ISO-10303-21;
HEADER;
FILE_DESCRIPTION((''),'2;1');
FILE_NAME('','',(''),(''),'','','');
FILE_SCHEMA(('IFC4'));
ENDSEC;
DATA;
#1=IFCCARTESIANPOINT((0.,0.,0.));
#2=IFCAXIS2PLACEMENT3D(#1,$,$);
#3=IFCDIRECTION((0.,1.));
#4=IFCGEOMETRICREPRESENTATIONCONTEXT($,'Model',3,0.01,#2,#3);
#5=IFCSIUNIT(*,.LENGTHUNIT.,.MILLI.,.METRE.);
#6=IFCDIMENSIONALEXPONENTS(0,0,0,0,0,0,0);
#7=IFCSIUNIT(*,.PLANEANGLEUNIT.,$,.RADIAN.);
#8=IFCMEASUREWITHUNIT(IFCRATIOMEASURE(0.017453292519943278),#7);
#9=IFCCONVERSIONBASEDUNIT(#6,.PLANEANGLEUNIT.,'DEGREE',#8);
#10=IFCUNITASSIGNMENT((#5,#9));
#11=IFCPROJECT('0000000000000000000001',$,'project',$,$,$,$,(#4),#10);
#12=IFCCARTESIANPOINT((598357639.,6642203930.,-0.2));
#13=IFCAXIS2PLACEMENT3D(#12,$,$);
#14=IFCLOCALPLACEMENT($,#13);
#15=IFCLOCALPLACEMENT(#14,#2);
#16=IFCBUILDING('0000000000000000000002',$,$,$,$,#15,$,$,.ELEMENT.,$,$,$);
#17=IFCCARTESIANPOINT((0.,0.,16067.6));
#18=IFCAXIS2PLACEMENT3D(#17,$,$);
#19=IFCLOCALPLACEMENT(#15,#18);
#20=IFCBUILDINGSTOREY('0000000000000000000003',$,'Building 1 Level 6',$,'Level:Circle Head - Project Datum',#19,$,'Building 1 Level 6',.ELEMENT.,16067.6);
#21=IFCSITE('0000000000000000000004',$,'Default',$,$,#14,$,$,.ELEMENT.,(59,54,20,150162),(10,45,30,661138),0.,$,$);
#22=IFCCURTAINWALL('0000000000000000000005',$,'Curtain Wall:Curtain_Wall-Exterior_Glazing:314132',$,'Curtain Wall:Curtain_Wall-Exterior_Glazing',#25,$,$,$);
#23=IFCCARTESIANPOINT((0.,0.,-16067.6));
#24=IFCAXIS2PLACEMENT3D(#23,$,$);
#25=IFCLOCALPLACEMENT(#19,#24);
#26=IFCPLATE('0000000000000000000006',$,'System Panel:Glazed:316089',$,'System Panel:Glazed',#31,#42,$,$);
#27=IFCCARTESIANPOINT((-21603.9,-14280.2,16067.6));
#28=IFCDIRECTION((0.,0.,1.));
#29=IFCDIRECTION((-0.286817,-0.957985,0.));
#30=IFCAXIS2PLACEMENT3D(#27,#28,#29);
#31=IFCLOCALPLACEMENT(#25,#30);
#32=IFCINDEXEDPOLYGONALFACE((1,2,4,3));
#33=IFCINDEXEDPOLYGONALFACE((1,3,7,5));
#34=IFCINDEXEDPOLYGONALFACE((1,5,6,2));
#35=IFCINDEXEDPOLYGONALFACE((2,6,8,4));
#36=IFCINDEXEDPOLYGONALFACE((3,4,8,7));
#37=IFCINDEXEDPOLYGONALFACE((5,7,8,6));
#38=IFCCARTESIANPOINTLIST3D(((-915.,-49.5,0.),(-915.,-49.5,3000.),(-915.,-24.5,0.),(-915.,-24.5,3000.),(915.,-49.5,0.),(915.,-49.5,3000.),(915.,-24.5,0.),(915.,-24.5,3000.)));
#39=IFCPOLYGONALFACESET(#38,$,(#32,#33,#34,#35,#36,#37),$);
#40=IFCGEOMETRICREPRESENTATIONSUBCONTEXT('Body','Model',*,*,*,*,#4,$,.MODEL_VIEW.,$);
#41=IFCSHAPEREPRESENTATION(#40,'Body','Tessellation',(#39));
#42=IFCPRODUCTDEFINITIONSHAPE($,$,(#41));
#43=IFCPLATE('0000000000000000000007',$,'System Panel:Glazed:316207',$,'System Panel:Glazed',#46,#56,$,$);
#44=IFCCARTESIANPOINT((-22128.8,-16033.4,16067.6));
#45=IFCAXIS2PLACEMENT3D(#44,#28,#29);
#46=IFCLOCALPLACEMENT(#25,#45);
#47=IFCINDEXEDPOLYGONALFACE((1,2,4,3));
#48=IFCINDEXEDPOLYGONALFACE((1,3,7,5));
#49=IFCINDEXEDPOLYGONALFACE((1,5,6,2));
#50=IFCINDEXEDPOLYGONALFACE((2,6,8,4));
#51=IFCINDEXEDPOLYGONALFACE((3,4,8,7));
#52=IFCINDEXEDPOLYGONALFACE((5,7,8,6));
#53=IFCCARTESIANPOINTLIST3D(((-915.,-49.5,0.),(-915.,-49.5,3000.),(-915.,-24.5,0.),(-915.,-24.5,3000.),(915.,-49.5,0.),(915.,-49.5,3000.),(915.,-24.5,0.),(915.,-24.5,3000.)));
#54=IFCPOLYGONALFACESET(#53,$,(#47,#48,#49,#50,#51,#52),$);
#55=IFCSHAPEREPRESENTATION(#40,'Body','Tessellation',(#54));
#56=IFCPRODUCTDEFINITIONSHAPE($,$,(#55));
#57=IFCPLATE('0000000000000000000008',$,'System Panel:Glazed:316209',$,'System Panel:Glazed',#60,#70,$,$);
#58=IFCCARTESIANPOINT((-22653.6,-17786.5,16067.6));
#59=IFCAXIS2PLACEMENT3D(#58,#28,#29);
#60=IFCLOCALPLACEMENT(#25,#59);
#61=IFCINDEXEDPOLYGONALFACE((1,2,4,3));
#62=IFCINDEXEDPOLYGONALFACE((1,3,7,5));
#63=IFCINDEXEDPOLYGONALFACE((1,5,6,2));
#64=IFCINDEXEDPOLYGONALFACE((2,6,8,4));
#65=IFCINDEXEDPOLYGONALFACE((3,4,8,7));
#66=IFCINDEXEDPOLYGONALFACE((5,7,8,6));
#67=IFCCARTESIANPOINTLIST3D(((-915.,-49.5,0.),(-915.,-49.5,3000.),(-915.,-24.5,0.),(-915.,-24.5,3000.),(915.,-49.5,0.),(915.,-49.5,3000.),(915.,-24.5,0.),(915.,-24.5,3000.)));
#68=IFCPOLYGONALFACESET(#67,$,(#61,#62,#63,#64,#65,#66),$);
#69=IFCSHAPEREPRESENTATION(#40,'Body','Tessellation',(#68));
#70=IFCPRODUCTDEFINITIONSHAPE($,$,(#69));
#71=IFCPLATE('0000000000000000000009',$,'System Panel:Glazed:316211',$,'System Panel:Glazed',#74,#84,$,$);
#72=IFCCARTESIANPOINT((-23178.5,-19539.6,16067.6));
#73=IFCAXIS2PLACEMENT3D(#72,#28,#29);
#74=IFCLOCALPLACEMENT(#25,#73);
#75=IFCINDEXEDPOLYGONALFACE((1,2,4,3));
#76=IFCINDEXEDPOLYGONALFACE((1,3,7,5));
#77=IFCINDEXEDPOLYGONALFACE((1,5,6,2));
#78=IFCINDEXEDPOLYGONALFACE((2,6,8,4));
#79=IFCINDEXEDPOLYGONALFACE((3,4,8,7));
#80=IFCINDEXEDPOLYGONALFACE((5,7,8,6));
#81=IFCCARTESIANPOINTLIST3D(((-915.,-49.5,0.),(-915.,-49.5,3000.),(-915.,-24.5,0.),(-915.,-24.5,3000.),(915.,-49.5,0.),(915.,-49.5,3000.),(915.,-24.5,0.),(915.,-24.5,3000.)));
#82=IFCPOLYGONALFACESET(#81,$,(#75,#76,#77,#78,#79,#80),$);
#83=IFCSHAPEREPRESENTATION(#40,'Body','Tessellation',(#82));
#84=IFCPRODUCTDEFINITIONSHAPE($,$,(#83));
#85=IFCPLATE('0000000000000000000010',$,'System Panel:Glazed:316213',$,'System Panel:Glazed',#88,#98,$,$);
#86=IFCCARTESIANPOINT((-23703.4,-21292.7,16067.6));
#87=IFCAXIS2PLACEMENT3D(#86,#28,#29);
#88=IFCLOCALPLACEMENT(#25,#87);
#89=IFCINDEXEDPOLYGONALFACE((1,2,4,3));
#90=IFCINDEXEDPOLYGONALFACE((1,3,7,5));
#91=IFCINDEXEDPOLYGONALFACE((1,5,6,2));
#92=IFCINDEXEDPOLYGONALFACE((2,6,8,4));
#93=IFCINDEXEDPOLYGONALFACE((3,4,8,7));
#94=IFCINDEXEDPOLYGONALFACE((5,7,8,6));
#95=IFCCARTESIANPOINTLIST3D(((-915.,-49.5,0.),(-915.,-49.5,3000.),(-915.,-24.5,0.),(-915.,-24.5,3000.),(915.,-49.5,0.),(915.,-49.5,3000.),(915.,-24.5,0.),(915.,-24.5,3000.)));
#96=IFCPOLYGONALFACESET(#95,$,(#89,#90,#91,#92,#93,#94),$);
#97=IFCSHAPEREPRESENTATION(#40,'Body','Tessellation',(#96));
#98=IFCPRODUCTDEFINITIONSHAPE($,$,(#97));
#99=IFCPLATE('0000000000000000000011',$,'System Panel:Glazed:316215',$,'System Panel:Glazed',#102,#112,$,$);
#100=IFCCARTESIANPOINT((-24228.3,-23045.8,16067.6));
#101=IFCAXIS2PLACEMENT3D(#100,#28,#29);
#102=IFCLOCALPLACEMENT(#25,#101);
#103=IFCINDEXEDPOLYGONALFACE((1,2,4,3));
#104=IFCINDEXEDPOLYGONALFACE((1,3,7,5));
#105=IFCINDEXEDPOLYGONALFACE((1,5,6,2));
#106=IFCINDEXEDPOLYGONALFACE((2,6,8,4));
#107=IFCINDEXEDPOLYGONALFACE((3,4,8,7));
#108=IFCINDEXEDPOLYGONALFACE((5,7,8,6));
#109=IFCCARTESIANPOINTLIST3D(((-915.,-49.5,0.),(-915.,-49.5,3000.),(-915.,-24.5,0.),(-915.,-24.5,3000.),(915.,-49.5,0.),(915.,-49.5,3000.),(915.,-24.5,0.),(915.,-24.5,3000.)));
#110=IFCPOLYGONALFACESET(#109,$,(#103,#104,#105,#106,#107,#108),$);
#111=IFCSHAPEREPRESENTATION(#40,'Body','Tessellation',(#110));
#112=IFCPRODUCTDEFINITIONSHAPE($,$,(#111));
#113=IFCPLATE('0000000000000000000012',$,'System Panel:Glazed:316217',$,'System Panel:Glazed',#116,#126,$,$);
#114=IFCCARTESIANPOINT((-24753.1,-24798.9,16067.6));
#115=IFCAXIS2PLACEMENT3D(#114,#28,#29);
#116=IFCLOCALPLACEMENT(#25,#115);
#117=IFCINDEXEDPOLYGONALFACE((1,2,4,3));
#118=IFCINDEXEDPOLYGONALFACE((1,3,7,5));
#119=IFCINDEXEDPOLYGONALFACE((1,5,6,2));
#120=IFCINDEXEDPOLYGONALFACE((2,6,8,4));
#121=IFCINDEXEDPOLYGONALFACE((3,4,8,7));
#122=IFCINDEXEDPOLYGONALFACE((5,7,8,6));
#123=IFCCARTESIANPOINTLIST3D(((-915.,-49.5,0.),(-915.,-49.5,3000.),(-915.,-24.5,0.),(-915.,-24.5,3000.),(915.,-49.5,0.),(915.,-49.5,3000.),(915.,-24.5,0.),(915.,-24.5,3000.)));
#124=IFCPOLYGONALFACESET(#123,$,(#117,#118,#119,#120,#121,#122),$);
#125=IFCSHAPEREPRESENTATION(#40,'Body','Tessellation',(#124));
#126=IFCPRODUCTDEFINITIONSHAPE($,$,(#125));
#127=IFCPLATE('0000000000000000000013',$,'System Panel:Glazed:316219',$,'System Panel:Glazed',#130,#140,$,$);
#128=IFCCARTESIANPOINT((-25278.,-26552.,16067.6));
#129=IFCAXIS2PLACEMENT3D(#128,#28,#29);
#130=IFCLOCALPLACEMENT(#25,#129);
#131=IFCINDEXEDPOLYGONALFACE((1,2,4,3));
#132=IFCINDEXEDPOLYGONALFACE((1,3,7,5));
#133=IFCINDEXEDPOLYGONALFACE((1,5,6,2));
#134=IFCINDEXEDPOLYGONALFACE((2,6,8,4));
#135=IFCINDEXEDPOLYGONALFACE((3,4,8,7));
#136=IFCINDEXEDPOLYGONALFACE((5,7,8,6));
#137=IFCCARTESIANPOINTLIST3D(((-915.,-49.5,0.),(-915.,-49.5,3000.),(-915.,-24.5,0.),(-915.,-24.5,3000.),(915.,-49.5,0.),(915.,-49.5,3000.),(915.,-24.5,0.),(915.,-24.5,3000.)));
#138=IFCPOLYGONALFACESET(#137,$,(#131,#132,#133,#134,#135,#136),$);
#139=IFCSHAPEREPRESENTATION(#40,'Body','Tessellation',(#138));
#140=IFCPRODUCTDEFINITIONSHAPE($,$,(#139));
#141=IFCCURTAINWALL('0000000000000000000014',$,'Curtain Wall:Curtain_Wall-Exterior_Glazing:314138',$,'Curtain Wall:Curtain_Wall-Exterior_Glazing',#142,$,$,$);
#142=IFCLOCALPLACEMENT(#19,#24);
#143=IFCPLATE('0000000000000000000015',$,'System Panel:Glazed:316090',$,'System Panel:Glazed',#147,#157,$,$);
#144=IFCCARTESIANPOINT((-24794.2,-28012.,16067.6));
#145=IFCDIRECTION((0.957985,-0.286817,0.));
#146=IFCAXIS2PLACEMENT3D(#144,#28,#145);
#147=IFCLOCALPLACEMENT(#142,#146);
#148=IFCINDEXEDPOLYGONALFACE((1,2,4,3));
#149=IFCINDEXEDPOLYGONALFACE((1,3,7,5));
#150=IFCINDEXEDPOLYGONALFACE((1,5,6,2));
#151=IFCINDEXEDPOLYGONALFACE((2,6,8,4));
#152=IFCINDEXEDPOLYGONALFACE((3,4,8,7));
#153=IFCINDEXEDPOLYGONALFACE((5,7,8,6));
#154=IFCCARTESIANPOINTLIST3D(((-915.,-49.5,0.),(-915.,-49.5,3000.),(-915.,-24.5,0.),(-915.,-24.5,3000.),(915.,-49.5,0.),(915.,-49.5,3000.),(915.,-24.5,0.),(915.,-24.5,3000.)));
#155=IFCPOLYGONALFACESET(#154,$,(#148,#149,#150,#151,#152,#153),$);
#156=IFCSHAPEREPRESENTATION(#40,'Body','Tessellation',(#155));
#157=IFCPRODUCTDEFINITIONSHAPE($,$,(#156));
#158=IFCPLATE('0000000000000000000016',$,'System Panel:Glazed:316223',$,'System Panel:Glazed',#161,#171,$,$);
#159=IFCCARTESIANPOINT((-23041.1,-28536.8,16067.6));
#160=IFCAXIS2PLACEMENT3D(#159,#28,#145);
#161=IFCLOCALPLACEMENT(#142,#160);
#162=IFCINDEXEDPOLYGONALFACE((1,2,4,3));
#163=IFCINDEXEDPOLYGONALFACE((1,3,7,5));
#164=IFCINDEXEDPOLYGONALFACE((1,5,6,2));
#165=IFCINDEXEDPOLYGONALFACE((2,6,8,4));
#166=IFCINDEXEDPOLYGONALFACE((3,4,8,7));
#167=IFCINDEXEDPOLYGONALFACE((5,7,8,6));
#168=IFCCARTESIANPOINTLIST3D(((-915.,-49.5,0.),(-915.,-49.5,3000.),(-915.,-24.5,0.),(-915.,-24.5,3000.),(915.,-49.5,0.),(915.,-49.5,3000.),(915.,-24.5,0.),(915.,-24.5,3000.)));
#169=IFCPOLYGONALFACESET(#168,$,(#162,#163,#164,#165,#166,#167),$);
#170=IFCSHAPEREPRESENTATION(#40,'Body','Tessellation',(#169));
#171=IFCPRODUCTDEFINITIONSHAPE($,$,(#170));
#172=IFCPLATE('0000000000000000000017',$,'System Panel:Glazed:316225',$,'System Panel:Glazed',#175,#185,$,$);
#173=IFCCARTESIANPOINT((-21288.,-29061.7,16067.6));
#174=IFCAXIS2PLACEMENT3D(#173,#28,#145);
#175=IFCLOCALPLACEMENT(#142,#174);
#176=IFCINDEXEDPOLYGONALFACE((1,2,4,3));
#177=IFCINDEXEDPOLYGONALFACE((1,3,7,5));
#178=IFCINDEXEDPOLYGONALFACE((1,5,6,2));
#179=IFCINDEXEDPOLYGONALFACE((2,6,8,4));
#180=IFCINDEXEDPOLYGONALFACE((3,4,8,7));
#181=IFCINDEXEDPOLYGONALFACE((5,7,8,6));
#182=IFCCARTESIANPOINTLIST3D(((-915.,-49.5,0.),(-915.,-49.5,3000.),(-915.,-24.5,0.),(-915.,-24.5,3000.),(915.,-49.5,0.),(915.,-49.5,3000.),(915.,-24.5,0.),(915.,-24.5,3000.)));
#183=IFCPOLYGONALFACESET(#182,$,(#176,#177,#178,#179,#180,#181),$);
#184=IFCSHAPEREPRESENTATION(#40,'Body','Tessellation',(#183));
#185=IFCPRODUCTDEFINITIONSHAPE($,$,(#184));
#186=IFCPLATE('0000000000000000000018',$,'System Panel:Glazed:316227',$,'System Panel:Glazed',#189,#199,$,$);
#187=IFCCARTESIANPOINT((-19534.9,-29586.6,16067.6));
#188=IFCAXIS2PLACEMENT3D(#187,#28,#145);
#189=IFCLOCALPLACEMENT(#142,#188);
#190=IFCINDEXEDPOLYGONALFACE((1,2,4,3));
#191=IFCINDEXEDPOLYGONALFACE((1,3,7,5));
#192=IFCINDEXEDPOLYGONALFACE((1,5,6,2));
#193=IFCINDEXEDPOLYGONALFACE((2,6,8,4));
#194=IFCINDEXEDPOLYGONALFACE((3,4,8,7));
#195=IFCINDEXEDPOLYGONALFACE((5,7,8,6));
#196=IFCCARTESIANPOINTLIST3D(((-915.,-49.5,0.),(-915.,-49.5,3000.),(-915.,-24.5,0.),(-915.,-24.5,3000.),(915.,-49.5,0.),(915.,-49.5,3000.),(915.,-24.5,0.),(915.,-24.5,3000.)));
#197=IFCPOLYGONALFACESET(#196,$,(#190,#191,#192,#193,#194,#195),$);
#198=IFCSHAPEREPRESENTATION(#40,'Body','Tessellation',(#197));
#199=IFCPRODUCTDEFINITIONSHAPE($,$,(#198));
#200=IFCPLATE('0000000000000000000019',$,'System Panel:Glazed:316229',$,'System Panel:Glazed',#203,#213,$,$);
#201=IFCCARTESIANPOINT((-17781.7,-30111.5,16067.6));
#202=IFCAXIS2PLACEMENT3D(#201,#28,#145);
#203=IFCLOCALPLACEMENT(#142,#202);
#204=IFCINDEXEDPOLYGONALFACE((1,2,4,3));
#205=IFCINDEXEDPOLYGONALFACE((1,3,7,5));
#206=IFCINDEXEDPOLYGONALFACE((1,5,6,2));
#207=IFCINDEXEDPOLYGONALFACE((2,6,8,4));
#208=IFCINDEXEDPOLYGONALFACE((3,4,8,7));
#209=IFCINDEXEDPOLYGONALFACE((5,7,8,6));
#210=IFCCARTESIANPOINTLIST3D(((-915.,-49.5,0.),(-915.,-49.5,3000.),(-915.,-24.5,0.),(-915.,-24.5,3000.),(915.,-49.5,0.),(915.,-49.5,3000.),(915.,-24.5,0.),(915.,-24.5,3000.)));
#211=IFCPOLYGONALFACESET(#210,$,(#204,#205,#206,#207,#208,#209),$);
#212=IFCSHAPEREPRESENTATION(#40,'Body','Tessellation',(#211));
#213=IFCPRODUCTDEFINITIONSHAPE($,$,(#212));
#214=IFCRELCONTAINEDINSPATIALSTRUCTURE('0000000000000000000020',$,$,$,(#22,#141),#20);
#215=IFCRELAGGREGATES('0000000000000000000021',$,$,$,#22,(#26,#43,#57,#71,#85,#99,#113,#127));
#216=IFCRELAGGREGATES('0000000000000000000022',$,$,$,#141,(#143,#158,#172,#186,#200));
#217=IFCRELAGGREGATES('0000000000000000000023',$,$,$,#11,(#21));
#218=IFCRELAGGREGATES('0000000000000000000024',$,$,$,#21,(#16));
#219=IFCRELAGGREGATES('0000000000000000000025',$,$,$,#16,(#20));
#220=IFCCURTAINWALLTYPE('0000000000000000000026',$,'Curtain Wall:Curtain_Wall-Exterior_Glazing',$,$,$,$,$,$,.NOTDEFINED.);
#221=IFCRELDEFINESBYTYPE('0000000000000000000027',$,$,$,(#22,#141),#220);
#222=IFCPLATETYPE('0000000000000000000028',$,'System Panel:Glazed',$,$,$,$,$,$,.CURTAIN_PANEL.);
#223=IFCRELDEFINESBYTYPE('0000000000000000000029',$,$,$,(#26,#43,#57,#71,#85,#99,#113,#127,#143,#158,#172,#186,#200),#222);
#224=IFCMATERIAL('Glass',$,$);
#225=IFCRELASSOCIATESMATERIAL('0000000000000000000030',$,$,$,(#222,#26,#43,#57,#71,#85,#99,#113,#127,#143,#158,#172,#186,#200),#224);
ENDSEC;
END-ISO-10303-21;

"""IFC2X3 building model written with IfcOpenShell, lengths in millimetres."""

from ifc_helpers import new_model, entity, si_unit, converted_unit, direction, frame, frame_2d, origin, place, context, subcontext, project, spatial, rectangle, extrude, source, transform, mapped, material, type_object, type_shapes, element, aggregate, save


model = new_model("IFC2X3")

# Units and contexts
model_context = context("Model", 3, precision=0.01, world=origin(), true_north=direction((0.0, 1.0)))
body_context = subcontext(model_context, "Body", "Model", "MODEL_VIEW")
ifc_project = project(units=[si_unit("LENGTHUNIT", "METRE", prefix="MILLI"), converted_unit("PLANEANGLEUNIT", "DEGREE", entity("IfcRatioMeasure", 0.017453292519943278), si_unit("PLANEANGLEUNIT", "RADIAN"), dimensions=[0, 0, 0, 0, 0, 0, 0])], contexts=[model_context])

# Site, building, storey
site_placement = place(None, frame((598357639.0, 6642203930.0, -0.2)))
site = spatial("IfcSite", under=ifc_project, at=site_placement, Name="Default", CompositionType="ELEMENT", RefLatitude=(59, 54, 20, 150162), RefLongitude=(10, 45, 30, 661138), RefElevation=0.0)
building_placement = place(site_placement, origin())
building = spatial("IfcBuilding", under=site, at=building_placement, CompositionType="ELEMENT")
storey_placement = place(building_placement, frame((0.0, 0.0, 16067.6)))
storey = spatial("IfcBuildingStorey", under=building, at=storey_placement, Name="Building 1 Level 6", ObjectType="Level:Circle Head - Project Datum", LongName="Building 1 Level 6", CompositionType="ELEMENT", Elevation=16067.6)

# Curtain walls, plates
curtain_wall_type = type_object("IfcCurtainWallType", Name="Curtain Wall:Curtain_Wall-Exterior_Glazing", PredefinedType="NOTDEFINED")
curtain_wall_1_placement = place(storey_placement, frame((0.0, 0.0, -16067.6)))
curtain_wall_1 = element("IfcCurtainWall", 1, at=curtain_wall_1_placement, inside=storey, type_object=curtain_wall_type, Name="Curtain Wall:Curtain_Wall-Exterior_Glazing:314132", ObjectType="Curtain Wall:Curtain_Wall-Exterior_Glazing")
ifc_material_1 = material(Name="Glass")
plate_type_1 = type_object("IfcPlateType", Name="System Panel:Glazed", PredefinedType="CURTAIN_PANEL", material=ifc_material_1)
shared_shape_1 = source(origin(), body_context, "Body", "SweptSolid", [
    extrude(rectangle(XDim=25.0, YDim=1830.0, at=frame_2d((0.0, 0.0), x_axis=(1.0, 0.0))), frame((0.0, -37.0, 0.0), z_axis=(0.0, 0.0, 1.0), x_axis=(0.0, 1.0, 0.0)), (0.0, 0.0, 1.0), 3000.0),
])
type_shapes(plate_type_1, [shared_shape_1])
plate_1_placement = place(curtain_wall_1_placement, frame((-21603.9, -14280.2, 16067.6), z_axis=(0.0, 0.0, 1.0), x_axis=(-0.286817, -0.957985, 0.0)))
plate_1 = element("IfcPlate", 2, at=plate_1_placement, type_object=plate_type_1, material=ifc_material_1, Name="System Panel:Glazed:316089", ObjectType="System Panel:Glazed", context=body_context, shape_type="MappedRepresentation", body=[
    mapped(shared_shape_1, transform((0.0, 0.0, 0.0), scale=1.0)),
])
plate_2_placement = place(curtain_wall_1_placement, frame((-22128.8, -16033.4, 16067.6), z_axis=(0.0, 0.0, 1.0), x_axis=(-0.286817, -0.957985, 0.0)))
plate_2 = element("IfcPlate", 3, at=plate_2_placement, type_object=plate_type_1, material=ifc_material_1, Name="System Panel:Glazed:316207", ObjectType="System Panel:Glazed", context=body_context, shape_type="MappedRepresentation", body=[
    mapped(shared_shape_1, transform((0.0, 0.0, 0.0), scale=1.0)),
])
plate_3_placement = place(curtain_wall_1_placement, frame((-22653.6, -17786.5, 16067.6), z_axis=(0.0, 0.0, 1.0), x_axis=(-0.286817, -0.957985, 0.0)))
plate_3 = element("IfcPlate", 4, at=plate_3_placement, type_object=plate_type_1, material=ifc_material_1, Name="System Panel:Glazed:316209", ObjectType="System Panel:Glazed", context=body_context, shape_type="MappedRepresentation", body=[
    mapped(shared_shape_1, transform((0.0, 0.0, 0.0), scale=1.0)),
])
plate_4_placement = place(curtain_wall_1_placement, frame((-23178.5, -19539.6, 16067.6), z_axis=(0.0, 0.0, 1.0), x_axis=(-0.286817, -0.957985, 0.0)))
plate_4 = element("IfcPlate", 5, at=plate_4_placement, type_object=plate_type_1, material=ifc_material_1, Name="System Panel:Glazed:316211", ObjectType="System Panel:Glazed", context=body_context, shape_type="MappedRepresentation", body=[
    mapped(shared_shape_1, transform((0.0, 0.0, 0.0), scale=1.0)),
])
plate_5_placement = place(curtain_wall_1_placement, frame((-23703.4, -21292.7, 16067.6), z_axis=(0.0, 0.0, 1.0), x_axis=(-0.286817, -0.957985, 0.0)))
plate_5 = element("IfcPlate", 6, at=plate_5_placement, type_object=plate_type_1, material=ifc_material_1, Name="System Panel:Glazed:316213", ObjectType="System Panel:Glazed", context=body_context, shape_type="MappedRepresentation", body=[
    mapped(shared_shape_1, transform((0.0, 0.0, 0.0), scale=1.0)),
])
plate_6_placement = place(curtain_wall_1_placement, frame((-24228.3, -23045.8, 16067.6), z_axis=(0.0, 0.0, 1.0), x_axis=(-0.286817, -0.957985, 0.0)))
plate_6 = element("IfcPlate", 7, at=plate_6_placement, type_object=plate_type_1, material=ifc_material_1, Name="System Panel:Glazed:316215", ObjectType="System Panel:Glazed", context=body_context, shape_type="MappedRepresentation", body=[
    mapped(shared_shape_1, transform((0.0, 0.0, 0.0), scale=1.0)),
])
plate_7_placement = place(curtain_wall_1_placement, frame((-24753.1, -24798.9, 16067.6), z_axis=(0.0, 0.0, 1.0), x_axis=(-0.286817, -0.957985, 0.0)))
plate_7 = element("IfcPlate", 8, at=plate_7_placement, type_object=plate_type_1, material=ifc_material_1, Name="System Panel:Glazed:316217", ObjectType="System Panel:Glazed", context=body_context, shape_type="MappedRepresentation", body=[
    mapped(shared_shape_1, transform((0.0, 0.0, 0.0), scale=1.0)),
])
plate_8_placement = place(curtain_wall_1_placement, frame((-25278.0, -26552.0, 16067.6), z_axis=(0.0, 0.0, 1.0), x_axis=(-0.286817, -0.957985, 0.0)))
plate_8 = element("IfcPlate", 9, at=plate_8_placement, type_object=plate_type_1, material=ifc_material_1, Name="System Panel:Glazed:316219", ObjectType="System Panel:Glazed", context=body_context, shape_type="MappedRepresentation", body=[
    mapped(shared_shape_1, transform((0.0, 0.0, 0.0), scale=1.0)),
])
curtain_wall_2_placement = place(storey_placement, frame((0.0, 0.0, -16067.6)))
curtain_wall_2 = element("IfcCurtainWall", 10, at=curtain_wall_2_placement, inside=storey, type_object=curtain_wall_type, Name="Curtain Wall:Curtain_Wall-Exterior_Glazing:314138", ObjectType="Curtain Wall:Curtain_Wall-Exterior_Glazing")
plate_9_placement = place(curtain_wall_2_placement, frame((-24794.2, -28012.0, 16067.6), z_axis=(0.0, 0.0, 1.0), x_axis=(0.957985, -0.286817, 0.0)))
plate_9 = element("IfcPlate", 11, at=plate_9_placement, type_object=plate_type_1, material=ifc_material_1, Name="System Panel:Glazed:316090", ObjectType="System Panel:Glazed", context=body_context, shape_type="MappedRepresentation", body=[
    mapped(shared_shape_1, transform((0.0, 0.0, 0.0), scale=1.0)),
])
plate_10_placement = place(curtain_wall_2_placement, frame((-23041.1, -28536.8, 16067.6), z_axis=(0.0, 0.0, 1.0), x_axis=(0.957985, -0.286817, 0.0)))
plate_10 = element("IfcPlate", 12, at=plate_10_placement, type_object=plate_type_1, material=ifc_material_1, Name="System Panel:Glazed:316223", ObjectType="System Panel:Glazed", context=body_context, shape_type="MappedRepresentation", body=[
    mapped(shared_shape_1, transform((0.0, 0.0, 0.0), scale=1.0)),
])
plate_11_placement = place(curtain_wall_2_placement, frame((-21288.0, -29061.7, 16067.6), z_axis=(0.0, 0.0, 1.0), x_axis=(0.957985, -0.286817, 0.0)))
plate_11 = element("IfcPlate", 13, at=plate_11_placement, type_object=plate_type_1, material=ifc_material_1, Name="System Panel:Glazed:316225", ObjectType="System Panel:Glazed", context=body_context, shape_type="MappedRepresentation", body=[
    mapped(shared_shape_1, transform((0.0, 0.0, 0.0), scale=1.0)),
])
plate_12_placement = place(curtain_wall_2_placement, frame((-19534.9, -29586.6, 16067.6), z_axis=(0.0, 0.0, 1.0), x_axis=(0.957985, -0.286817, 0.0)))
plate_12 = element("IfcPlate", 14, at=plate_12_placement, type_object=plate_type_1, material=ifc_material_1, Name="System Panel:Glazed:316227", ObjectType="System Panel:Glazed", context=body_context, shape_type="MappedRepresentation", body=[
    mapped(shared_shape_1, transform((0.0, 0.0, 0.0), scale=1.0)),
])
plate_13_placement = place(curtain_wall_2_placement, frame((-17781.7, -30111.5, 16067.6), z_axis=(0.0, 0.0, 1.0), x_axis=(0.957985, -0.286817, 0.0)))
plate_13 = element("IfcPlate", 15, at=plate_13_placement, type_object=plate_type_1, material=ifc_material_1, Name="System Panel:Glazed:316229", ObjectType="System Panel:Glazed", context=body_context, shape_type="MappedRepresentation", body=[
    mapped(shared_shape_1, transform((0.0, 0.0, 0.0), scale=1.0)),
])

aggregate(curtain_wall_1, [plate_1, plate_2, plate_3, plate_4, plate_5, plate_6, plate_7, plate_8])
aggregate(curtain_wall_2, [plate_9, plate_10, plate_11, plate_12, plate_13])

save(model, "model.ifc")
